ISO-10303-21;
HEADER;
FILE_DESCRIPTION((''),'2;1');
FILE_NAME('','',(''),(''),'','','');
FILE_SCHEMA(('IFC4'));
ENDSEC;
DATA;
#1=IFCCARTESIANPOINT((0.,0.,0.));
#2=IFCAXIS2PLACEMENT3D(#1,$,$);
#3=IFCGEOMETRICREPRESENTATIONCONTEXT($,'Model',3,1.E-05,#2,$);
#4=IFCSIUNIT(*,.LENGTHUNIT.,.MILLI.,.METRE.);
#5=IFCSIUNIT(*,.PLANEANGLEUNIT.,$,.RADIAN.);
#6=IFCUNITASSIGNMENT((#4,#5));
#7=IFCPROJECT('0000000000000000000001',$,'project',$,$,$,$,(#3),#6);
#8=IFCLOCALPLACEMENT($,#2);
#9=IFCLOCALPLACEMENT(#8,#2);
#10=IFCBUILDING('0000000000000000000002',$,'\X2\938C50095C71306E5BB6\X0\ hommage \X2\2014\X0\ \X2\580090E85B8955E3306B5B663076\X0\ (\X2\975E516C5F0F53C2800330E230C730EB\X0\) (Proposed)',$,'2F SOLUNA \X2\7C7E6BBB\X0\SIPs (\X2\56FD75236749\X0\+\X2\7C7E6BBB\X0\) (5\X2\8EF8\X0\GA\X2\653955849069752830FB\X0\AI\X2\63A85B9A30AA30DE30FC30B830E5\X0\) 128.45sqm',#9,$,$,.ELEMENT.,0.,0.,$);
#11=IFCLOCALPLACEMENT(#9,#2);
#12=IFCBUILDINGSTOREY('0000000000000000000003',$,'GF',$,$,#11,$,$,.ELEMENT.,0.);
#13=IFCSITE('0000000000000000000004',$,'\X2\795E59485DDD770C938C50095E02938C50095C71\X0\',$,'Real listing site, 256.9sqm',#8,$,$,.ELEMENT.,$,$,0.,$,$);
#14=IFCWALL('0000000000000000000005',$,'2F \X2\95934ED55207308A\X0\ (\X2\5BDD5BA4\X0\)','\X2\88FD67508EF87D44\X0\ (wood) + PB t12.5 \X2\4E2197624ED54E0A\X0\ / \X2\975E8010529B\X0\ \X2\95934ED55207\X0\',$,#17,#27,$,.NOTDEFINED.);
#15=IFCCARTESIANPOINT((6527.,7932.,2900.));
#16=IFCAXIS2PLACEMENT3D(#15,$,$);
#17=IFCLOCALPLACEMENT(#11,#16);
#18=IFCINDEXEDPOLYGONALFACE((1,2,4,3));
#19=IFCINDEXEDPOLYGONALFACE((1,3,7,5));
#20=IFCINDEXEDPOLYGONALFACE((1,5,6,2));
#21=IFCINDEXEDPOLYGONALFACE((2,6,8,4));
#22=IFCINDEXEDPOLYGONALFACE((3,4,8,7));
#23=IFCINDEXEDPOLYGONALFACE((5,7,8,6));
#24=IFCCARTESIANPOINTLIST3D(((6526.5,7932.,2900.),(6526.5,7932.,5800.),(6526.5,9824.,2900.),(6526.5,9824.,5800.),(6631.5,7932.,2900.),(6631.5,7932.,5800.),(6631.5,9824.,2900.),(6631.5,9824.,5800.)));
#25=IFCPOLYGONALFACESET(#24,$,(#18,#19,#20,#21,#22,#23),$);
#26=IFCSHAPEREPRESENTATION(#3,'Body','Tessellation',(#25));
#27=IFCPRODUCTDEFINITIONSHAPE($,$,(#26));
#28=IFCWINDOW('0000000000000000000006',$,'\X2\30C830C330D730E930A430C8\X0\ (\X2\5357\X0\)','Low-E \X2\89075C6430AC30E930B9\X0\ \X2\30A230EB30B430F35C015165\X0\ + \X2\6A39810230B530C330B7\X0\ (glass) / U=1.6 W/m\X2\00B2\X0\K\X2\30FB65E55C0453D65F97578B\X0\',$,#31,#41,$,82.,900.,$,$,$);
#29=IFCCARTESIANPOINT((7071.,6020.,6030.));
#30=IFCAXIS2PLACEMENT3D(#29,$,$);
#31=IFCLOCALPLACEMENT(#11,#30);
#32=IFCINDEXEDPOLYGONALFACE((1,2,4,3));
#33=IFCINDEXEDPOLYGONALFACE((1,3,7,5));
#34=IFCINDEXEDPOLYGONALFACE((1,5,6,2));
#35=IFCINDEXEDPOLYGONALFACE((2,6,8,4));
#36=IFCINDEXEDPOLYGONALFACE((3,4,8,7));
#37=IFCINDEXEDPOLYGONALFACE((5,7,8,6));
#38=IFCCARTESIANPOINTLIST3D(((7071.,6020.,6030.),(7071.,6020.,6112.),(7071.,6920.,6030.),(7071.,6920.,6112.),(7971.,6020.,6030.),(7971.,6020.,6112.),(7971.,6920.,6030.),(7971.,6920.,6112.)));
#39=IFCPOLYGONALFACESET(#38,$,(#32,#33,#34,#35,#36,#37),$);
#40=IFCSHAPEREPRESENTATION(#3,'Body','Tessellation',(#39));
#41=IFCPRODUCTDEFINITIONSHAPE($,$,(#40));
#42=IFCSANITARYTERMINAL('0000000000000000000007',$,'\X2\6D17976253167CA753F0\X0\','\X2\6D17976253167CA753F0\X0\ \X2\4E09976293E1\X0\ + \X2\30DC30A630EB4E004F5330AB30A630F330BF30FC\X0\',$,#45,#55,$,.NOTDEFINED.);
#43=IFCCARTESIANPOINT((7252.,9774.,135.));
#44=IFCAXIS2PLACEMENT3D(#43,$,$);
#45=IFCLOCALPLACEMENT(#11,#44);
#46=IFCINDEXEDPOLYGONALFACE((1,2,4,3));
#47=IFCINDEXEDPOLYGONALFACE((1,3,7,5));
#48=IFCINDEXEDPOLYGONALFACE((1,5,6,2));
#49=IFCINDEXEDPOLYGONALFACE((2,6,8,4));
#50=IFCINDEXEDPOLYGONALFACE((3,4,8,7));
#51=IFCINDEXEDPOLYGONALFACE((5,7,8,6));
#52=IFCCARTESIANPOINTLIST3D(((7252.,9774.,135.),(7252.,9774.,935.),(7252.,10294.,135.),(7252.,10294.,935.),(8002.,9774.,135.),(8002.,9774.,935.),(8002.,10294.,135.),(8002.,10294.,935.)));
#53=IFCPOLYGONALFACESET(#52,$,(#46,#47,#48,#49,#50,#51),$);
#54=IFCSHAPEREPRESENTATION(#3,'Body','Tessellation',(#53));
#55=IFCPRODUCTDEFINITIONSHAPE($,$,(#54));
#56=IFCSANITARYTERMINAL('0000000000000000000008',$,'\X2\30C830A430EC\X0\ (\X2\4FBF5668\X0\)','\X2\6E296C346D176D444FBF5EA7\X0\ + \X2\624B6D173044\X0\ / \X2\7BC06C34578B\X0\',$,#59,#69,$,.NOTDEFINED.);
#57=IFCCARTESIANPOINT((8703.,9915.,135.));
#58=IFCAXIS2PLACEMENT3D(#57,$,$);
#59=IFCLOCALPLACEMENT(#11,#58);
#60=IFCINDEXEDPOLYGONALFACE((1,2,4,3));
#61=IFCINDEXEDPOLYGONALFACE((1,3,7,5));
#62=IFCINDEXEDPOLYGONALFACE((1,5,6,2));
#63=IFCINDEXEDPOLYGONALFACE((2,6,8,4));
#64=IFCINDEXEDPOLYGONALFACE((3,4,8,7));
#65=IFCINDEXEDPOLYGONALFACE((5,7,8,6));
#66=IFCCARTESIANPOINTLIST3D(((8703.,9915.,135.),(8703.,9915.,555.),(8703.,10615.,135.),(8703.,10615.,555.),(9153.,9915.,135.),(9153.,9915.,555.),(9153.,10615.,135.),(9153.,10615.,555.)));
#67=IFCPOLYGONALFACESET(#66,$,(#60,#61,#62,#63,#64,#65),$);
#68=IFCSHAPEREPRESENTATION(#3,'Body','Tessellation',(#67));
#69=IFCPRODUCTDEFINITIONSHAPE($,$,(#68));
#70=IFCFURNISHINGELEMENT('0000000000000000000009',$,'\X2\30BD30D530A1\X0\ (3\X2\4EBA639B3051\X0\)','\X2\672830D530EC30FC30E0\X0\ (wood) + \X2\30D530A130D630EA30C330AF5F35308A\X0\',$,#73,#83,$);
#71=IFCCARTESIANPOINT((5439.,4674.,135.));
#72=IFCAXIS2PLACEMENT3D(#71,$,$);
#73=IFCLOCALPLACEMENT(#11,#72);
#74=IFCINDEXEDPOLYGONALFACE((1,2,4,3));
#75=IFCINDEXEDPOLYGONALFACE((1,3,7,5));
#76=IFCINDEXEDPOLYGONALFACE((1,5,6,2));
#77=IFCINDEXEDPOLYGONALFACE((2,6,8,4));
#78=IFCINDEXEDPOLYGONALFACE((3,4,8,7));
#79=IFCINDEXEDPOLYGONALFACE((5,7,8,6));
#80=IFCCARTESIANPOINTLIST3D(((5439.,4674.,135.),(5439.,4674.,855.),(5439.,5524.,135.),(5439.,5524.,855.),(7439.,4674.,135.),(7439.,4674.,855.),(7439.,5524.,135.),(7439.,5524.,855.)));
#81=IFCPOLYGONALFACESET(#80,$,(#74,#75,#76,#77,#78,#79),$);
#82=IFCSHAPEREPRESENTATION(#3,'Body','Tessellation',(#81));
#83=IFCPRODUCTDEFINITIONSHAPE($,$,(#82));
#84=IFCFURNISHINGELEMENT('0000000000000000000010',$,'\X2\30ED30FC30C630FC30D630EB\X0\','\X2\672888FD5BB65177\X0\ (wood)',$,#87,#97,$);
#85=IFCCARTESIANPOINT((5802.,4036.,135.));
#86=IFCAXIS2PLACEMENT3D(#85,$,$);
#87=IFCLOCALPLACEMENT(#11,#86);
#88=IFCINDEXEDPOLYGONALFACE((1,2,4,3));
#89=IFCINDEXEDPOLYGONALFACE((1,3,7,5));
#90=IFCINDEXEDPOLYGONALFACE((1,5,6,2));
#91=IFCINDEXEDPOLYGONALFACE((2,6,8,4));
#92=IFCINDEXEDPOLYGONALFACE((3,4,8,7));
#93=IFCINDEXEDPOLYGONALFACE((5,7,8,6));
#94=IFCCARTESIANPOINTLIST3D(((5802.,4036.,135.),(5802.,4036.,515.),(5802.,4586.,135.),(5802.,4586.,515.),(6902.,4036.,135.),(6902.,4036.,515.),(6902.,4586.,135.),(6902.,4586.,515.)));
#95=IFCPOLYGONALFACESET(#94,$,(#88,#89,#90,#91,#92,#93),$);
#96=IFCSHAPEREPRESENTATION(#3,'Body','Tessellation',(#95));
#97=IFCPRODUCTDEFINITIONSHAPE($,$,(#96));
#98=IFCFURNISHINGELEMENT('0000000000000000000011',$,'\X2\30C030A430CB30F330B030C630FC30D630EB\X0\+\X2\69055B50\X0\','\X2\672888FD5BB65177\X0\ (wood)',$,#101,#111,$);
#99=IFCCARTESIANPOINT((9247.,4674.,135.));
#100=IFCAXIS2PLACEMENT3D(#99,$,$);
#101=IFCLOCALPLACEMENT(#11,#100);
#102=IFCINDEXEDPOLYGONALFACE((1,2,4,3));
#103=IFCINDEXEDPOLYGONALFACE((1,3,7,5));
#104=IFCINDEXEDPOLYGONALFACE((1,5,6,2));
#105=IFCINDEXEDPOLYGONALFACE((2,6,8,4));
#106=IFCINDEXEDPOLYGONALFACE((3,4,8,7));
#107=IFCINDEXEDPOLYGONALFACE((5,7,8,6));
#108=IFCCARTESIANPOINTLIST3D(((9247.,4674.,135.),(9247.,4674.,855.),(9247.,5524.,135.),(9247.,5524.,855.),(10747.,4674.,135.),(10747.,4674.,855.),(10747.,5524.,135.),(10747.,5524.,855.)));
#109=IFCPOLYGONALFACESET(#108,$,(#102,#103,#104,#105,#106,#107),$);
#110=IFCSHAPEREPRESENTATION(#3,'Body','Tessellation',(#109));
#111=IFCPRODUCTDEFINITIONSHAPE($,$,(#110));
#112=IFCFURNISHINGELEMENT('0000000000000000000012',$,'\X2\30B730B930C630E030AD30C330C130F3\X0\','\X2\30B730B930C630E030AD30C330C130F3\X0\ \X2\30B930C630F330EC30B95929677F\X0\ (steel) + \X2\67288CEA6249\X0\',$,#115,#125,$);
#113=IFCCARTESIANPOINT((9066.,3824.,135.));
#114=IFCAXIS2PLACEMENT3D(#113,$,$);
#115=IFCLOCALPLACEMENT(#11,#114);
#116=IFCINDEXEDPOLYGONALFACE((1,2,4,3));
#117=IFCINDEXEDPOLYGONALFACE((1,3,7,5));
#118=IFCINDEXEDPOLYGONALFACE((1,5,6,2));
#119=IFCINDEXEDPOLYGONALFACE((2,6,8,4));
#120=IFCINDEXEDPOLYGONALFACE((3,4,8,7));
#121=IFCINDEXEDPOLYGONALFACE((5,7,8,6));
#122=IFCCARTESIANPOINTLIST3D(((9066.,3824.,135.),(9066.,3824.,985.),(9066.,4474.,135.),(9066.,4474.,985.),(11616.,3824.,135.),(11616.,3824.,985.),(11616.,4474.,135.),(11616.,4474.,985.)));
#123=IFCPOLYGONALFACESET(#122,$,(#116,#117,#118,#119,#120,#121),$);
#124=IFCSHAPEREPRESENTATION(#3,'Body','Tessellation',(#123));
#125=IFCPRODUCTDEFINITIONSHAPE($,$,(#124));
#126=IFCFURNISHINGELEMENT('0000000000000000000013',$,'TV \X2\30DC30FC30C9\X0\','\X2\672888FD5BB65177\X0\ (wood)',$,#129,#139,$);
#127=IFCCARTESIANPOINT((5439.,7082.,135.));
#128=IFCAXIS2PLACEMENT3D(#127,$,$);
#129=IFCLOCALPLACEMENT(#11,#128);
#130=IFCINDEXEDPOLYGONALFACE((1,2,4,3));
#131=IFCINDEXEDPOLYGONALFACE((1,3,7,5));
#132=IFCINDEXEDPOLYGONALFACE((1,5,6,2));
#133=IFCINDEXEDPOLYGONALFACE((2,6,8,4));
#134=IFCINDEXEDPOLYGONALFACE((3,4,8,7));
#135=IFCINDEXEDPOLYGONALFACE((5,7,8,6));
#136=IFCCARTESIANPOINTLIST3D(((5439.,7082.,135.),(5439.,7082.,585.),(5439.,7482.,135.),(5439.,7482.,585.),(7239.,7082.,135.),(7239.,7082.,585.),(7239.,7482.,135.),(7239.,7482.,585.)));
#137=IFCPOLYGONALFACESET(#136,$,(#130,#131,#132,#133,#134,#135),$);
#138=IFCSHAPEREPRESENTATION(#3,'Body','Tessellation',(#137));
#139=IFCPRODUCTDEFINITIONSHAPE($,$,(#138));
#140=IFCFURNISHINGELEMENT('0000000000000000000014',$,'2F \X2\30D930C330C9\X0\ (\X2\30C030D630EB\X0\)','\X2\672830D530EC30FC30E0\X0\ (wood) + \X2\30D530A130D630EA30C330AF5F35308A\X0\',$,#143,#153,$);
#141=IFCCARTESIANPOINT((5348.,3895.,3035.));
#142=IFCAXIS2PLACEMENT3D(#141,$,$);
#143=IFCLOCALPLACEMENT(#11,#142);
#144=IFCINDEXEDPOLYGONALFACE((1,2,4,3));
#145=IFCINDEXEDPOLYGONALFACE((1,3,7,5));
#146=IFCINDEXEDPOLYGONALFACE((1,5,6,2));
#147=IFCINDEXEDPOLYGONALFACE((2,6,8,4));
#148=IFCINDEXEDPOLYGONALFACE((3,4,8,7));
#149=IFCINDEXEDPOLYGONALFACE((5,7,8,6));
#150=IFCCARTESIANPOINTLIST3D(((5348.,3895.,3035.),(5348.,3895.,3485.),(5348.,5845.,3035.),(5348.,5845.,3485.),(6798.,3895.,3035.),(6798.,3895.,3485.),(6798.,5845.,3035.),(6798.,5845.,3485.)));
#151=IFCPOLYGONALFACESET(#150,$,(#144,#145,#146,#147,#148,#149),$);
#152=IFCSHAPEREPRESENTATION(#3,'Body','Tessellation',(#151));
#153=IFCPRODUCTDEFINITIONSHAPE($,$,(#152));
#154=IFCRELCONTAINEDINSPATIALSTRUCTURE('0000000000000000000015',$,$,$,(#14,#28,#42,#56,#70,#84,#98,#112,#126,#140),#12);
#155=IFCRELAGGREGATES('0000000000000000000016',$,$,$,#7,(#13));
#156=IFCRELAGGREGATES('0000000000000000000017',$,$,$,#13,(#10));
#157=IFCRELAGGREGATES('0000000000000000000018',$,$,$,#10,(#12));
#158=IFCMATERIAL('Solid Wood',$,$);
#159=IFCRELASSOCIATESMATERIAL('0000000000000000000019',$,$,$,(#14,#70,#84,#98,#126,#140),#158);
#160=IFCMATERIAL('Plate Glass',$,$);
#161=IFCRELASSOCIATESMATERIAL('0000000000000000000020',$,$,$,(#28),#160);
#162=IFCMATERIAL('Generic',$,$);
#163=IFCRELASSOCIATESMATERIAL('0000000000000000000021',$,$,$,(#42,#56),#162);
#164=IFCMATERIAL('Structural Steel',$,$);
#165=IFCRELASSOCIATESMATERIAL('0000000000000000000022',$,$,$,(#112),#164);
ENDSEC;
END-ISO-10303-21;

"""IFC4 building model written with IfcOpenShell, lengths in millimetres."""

from ifc_helpers import new_model, si_unit, frame, frame_2d, origin, place, context, project, spatial, rectangle, extrude, material, element, save


model = new_model("IFC4")

# Units and contexts
model_context = context("Model", 3, precision=1e-05, world=origin())
ifc_project = project(units=[si_unit("LENGTHUNIT", "METRE", prefix="MILLI"), si_unit("PLANEANGLEUNIT", "RADIAN")], contexts=[model_context])

# Site, building, storey
site_placement = place(None, origin())
site = spatial("IfcSite", under=ifc_project, at=site_placement, Name="神奈川県鎌倉市鎌倉山", ObjectType="Real listing site, 256.9sqm", CompositionType="ELEMENT", RefElevation=0.0)
building_placement = place(site_placement, origin())
building = spatial("IfcBuilding", under=site, at=building_placement, Name="鎌倉山の家 hommage — 堀部安嗣に学ぶ (非公式参考モデル) (Proposed)", ObjectType="2F SOLUNA 籾殻SIPs (国産杉+籾殻) (5軸GA改善適用・AI推定オマージュ) 128.45sqm", CompositionType="ELEMENT", ElevationOfRefHeight=0.0, ElevationOfTerrain=0.0)
storey_placement = place(building_placement, origin())
storey = spatial("IfcBuildingStorey", under=building, at=storey_placement, Name="GF", CompositionType="ELEMENT", Elevation=0.0)

# Shared definitions
ifc_material_1 = material(Name="Solid Wood")

# Wall
wall_1_placement = place(storey_placement, frame((6527.0, 7932.0, 2900.0)))
element("IfcWall", 1, at=wall_1_placement, inside=storey, material=ifc_material_1, Name="2F 間仕切り (寝室)", Description="製材軸組 (wood) + PB t12.5 両面仕上 / 非耐力 間仕切", PredefinedType="NOTDEFINED", context=model_context, shape_type="SweptSolid", body=[
    extrude(rectangle(XDim=105.0, YDim=1892.0, at=frame_2d((52.0, 946.0))), frame((6527.0, 7932.0, 2900.0)), (0.0, 0.0, 1.0), 2900.0),
])

# Window
ifc_material_2 = material(Name="Plate Glass")
window_placement = place(storey_placement, frame((7071.0, 6020.0, 6030.0)))
element("IfcWindow", 2, at=window_placement, inside=storey, material=ifc_material_2, Name="トップライト (南)", Description="Low-E 複層ガラス アルゴン封入 + 樹脂サッシ (glass) / U=1.6 W/m²K・日射取得型", OverallHeight=82.0, OverallWidth=900.0, context=model_context, shape_type="SweptSolid", body=[
    extrude(rectangle(XDim=900.0, YDim=900.0, at=frame_2d((450.0, 450.0))), frame((7071.0, 6020.0, 6030.0)), (0.0, 0.0, 1.0), 82.0),
])

# Sanitary terminals
ifc_material_3 = material(Name="Generic")
sanitary_terminal_1_placement = place(storey_placement, frame((7252.0, 9774.0, 135.0)))
element("IfcSanitaryTerminal", 3, at=sanitary_terminal_1_placement, inside=storey, material=ifc_material_3, Name="洗面化粧台", Description="洗面化粧台 三面鏡 + ボウル一体カウンター", PredefinedType="NOTDEFINED", context=model_context, shape_type="SweptSolid", body=[
    extrude(rectangle(XDim=750.0, YDim=520.0, at=frame_2d((375.0, 260.0))), frame((7252.0, 9774.0, 135.0)), (0.0, 0.0, 1.0), 800.0),
])
sanitary_terminal_2_placement = place(storey_placement, frame((8703.0, 9915.0, 135.0)))
element("IfcSanitaryTerminal", 4, at=sanitary_terminal_2_placement, inside=storey, material=ifc_material_3, Name="トイレ (便器)", Description="温水洗浄便座 + 手洗い / 節水型", PredefinedType="NOTDEFINED", context=model_context, shape_type="SweptSolid", body=[
    extrude(rectangle(XDim=450.0, YDim=700.0, at=frame_2d((225.0, 350.0))), frame((8703.0, 9915.0, 135.0)), (0.0, 0.0, 1.0), 420.0),
])

# Furnishing elements
furnishing_1_placement = place(storey_placement, frame((5439.0, 4674.0, 135.0)))
element("IfcFurnishingElement", 5, at=furnishing_1_placement, inside=storey, material=ifc_material_1, Name="ソファ (3人掛け)", Description="木フレーム (wood) + ファブリック張り", context=model_context, shape_type="SweptSolid", body=[
    extrude(rectangle(XDim=2000.0, YDim=850.0, at=frame_2d((1000.0, 425.0))), frame((5439.0, 4674.0, 135.0)), (0.0, 0.0, 1.0), 720.0),
])
furnishing_2_placement = place(storey_placement, frame((5802.0, 4036.0, 135.0)))
element("IfcFurnishingElement", 6, at=furnishing_2_placement, inside=storey, material=ifc_material_1, Name="ローテーブル", Description="木製家具 (wood)", context=model_context, shape_type="SweptSolid", body=[
    extrude(rectangle(XDim=1100.0, YDim=550.0, at=frame_2d((550.0, 275.0))), frame((5802.0, 4036.0, 135.0)), (0.0, 0.0, 1.0), 380.0),
])
furnishing_3_placement = place(storey_placement, frame((9247.0, 4674.0, 135.0)))
element("IfcFurnishingElement", 7, at=furnishing_3_placement, inside=storey, material=ifc_material_1, Name="ダイニングテーブル+椅子", Description="木製家具 (wood)", context=model_context, shape_type="SweptSolid", body=[
    extrude(rectangle(XDim=1500.0, YDim=850.0, at=frame_2d((750.0, 425.0))), frame((9247.0, 4674.0, 135.0)), (0.0, 0.0, 1.0), 720.0),
])
ifc_material_4 = material(Name="Structural Steel")
furnishing_4_placement = place(storey_placement, frame((9066.0, 3824.0, 135.0)))
element("IfcFurnishingElement", 8, at=furnishing_4_placement, inside=storey, material=ifc_material_4, Name="システムキッチン", Description="システムキッチン ステンレス天板 (steel) + 木質扉", context=model_context, shape_type="SweptSolid", body=[
    extrude(rectangle(XDim=2550.0, YDim=650.0, at=frame_2d((1275.0, 325.0))), frame((9066.0, 3824.0, 135.0)), (0.0, 0.0, 1.0), 850.0),
])
furnishing_5_placement = place(storey_placement, frame((5439.0, 7082.0, 135.0)))
element("IfcFurnishingElement", 9, at=furnishing_5_placement, inside=storey, material=ifc_material_1, Name="TV ボード", Description="木製家具 (wood)", context=model_context, shape_type="SweptSolid", body=[
    extrude(rectangle(XDim=1800.0, YDim=400.0, at=frame_2d((900.0, 200.0))), frame((5439.0, 7082.0, 135.0)), (0.0, 0.0, 1.0), 450.0),
])
furnishing_6_placement = place(storey_placement, frame((5348.0, 3895.0, 3035.0)))
element("IfcFurnishingElement", 10, at=furnishing_6_placement, inside=storey, material=ifc_material_1, Name="2F ベッド (ダブル)", Description="木フレーム (wood) + ファブリック張り", context=model_context, shape_type="SweptSolid", body=[
    extrude(rectangle(XDim=1450.0, YDim=1950.0, at=frame_2d((725.0, 975.0))), frame((5348.0, 3895.0, 3035.0)), (0.0, 0.0, 1.0), 450.0),
])

save(model, "model.ifc")
